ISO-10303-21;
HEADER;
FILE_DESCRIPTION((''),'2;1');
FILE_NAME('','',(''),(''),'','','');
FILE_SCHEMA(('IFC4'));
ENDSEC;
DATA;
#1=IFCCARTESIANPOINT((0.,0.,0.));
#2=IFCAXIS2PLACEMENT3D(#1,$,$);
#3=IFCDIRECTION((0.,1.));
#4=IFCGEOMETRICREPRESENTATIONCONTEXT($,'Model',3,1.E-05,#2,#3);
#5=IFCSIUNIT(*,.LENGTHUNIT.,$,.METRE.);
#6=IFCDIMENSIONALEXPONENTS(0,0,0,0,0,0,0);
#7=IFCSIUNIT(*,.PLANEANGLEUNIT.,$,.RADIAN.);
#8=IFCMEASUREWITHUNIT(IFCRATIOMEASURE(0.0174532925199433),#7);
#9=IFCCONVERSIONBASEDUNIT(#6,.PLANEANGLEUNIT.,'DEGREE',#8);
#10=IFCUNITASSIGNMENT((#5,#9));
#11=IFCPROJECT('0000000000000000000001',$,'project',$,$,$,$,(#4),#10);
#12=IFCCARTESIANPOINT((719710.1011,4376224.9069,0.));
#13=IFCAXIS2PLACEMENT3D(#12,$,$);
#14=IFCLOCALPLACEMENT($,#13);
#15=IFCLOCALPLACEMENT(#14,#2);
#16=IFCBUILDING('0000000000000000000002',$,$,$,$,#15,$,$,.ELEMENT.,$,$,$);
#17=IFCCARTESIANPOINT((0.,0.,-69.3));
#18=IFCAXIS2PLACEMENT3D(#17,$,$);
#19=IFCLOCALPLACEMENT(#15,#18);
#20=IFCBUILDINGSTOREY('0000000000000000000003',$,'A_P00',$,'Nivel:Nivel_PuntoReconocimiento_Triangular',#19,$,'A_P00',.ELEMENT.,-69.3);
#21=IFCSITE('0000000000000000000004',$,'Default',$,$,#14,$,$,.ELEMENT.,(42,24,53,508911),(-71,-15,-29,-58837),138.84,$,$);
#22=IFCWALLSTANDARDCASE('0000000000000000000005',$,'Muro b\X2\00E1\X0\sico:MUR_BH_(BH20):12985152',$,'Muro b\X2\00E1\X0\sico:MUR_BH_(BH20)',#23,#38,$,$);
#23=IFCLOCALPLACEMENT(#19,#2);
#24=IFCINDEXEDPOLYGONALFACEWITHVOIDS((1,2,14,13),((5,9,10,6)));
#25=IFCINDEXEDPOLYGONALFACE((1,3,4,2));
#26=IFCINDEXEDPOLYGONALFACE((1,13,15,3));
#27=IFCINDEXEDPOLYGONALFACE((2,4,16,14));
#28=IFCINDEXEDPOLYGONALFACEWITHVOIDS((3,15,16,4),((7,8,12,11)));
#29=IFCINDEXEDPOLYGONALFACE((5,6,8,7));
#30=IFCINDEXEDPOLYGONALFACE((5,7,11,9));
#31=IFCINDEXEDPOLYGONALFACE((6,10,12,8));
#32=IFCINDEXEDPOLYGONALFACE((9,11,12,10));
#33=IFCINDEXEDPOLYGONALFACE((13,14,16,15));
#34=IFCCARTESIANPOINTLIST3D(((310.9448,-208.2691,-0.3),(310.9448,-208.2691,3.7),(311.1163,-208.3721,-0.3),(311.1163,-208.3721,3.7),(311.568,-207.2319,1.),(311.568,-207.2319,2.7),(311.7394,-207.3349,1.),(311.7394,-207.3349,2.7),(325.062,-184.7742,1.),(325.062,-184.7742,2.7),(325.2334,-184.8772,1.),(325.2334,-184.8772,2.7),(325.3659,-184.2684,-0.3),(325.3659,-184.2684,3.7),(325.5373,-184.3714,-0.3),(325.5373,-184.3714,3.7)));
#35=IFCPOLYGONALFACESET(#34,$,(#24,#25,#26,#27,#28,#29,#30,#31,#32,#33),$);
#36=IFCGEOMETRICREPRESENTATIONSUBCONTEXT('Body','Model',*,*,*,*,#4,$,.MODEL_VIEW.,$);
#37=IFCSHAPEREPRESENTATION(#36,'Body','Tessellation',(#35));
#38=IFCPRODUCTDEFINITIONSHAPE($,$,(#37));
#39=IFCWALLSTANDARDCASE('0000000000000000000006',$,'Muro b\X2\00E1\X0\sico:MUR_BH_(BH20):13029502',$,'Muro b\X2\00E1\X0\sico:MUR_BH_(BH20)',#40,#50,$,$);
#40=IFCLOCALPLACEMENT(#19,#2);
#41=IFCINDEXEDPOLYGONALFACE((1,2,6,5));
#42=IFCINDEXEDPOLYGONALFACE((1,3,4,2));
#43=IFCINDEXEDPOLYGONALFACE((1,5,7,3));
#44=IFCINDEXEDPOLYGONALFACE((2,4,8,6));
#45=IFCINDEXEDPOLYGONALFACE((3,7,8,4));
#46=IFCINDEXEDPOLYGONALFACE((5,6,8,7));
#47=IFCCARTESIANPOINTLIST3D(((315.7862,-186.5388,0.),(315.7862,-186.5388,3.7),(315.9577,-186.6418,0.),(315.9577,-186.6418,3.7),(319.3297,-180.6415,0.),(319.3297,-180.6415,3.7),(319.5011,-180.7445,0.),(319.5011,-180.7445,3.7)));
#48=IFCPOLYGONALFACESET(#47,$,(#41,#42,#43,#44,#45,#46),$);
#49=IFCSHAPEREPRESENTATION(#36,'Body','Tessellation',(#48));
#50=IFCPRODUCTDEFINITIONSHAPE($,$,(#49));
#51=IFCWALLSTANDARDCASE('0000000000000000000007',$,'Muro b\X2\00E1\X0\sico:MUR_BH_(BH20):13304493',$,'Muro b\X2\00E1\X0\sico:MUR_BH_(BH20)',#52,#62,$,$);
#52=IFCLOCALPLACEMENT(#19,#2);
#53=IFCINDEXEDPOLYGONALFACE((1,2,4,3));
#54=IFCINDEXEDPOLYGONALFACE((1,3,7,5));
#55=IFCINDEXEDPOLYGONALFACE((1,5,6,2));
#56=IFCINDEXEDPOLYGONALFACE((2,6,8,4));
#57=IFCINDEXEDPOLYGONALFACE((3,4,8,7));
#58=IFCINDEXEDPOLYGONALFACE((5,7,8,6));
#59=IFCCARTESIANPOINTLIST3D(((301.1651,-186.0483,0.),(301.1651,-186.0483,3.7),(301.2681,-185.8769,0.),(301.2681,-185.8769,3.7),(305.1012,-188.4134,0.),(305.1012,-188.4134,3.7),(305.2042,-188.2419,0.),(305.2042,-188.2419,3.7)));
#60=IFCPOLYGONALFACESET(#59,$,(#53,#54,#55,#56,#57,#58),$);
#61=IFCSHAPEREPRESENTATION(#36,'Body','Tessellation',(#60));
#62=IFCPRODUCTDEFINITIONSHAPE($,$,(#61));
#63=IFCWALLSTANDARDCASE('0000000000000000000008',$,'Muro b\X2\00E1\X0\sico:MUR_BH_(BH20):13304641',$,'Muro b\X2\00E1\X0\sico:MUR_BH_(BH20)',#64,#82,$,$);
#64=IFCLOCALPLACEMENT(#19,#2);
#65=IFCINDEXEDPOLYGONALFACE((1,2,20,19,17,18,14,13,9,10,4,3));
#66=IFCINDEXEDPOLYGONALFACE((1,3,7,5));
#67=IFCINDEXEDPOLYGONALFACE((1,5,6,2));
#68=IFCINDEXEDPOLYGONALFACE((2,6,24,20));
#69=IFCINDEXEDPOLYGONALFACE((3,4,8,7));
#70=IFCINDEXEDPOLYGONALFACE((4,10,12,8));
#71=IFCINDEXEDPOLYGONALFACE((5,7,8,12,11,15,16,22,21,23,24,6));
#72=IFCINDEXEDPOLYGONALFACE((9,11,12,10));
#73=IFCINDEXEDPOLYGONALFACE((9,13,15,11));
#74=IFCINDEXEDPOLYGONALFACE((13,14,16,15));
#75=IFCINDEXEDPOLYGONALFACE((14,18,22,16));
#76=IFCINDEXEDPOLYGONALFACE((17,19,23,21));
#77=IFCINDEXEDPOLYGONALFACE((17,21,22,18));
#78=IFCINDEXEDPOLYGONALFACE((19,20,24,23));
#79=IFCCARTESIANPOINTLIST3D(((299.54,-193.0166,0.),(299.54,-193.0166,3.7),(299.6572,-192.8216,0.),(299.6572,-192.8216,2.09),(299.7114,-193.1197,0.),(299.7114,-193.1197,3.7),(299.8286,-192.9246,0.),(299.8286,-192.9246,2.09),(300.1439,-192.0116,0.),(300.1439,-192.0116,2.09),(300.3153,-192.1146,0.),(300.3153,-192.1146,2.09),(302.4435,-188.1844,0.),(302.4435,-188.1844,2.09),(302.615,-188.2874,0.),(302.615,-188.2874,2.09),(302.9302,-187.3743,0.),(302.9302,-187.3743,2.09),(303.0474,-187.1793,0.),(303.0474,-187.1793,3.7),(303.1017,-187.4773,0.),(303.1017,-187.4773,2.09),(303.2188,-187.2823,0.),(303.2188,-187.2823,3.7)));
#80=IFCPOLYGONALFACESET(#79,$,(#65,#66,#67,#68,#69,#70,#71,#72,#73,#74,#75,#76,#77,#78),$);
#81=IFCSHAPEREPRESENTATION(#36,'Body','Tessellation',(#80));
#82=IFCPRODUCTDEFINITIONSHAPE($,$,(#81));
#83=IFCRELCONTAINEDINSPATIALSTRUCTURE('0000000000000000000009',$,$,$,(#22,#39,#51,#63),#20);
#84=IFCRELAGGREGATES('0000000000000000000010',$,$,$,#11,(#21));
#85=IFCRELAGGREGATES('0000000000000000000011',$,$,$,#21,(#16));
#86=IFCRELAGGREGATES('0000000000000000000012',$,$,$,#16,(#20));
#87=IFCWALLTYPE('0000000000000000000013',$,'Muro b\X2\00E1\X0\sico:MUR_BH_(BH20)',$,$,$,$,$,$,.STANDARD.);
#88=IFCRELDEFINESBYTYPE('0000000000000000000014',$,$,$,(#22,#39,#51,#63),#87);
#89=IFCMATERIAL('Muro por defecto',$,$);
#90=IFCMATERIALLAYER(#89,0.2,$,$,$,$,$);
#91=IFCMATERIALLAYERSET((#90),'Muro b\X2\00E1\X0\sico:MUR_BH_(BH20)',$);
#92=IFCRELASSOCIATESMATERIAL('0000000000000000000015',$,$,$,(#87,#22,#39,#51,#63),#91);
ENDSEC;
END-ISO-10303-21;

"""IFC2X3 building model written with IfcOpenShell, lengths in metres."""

from ifc_helpers import new_model, entity, si_unit, converted_unit, direction, frame, frame_2d, origin, place, context, subcontext, project, spatial, rectangle, extrude, material, layer, layer_set, layer_usage, type_object, element, save


model = new_model("IFC2X3")

# Units and contexts
model_context = context("Model", 3, precision=1e-05, world=origin(), true_north=direction((0.0, 1.0)))
body_context = subcontext(model_context, "Body", "Model", "MODEL_VIEW")
ifc_project = project(units=[si_unit("LENGTHUNIT", "METRE"), converted_unit("PLANEANGLEUNIT", "DEGREE", entity("IfcRatioMeasure", 0.0174532925199433), si_unit("PLANEANGLEUNIT", "RADIAN"), dimensions=[0, 0, 0, 0, 0, 0, 0])], contexts=[model_context])

# Site, building, storey
site_placement = place(None, frame((719710.1011, 4376224.9069, 0.0)))
site = spatial("IfcSite", under=ifc_project, at=site_placement, Name="Default", CompositionType="ELEMENT", RefLatitude=(42, 24, 53, 508911), RefLongitude=(-71, -15, -29, -58837), RefElevation=138.84)
building_placement = place(site_placement, origin())
building = spatial("IfcBuilding", under=site, at=building_placement, CompositionType="ELEMENT")
storey_placement = place(building_placement, frame((0.0, 0.0, -69.3)))
storey = spatial("IfcBuildingStorey", under=building, at=storey_placement, Name="A_P00", ObjectType="Nivel:Nivel_PuntoReconocimiento_Triangular", LongName="A_P00", CompositionType="ELEMENT", Elevation=-69.3)

# Wall, opening
ifc_material_1 = material(Name="Muro por defecto")
ifc_layer_1 = layer(ifc_material_1, 0.2)
ifc_layer_set_1 = layer_set([ifc_layer_1], Name="Muro básico:MUR_BH_(BH20)")
ifc_layer_usage_1 = layer_usage(ifc_layer_set_1, "AXIS2", "NEGATIVE", 0.1)
wall_type = type_object("IfcWallType", Name="Muro básico:MUR_BH_(BH20)", PredefinedType="STANDARD", material=ifc_layer_set_1)
wall_1_placement = place(storey_placement, frame((325.4516, -184.3199, -0.3), z_axis=(0.0, 0.0, 1.0), x_axis=(-0.515038, -0.857167, 0.0)))
wall_1 = element("IfcWallStandardCase", 1, at=wall_1_placement, inside=storey, type_object=wall_type, material=ifc_layer_usage_1, Name="Muro básico:MUR_BH_(BH20):12985152", ObjectType="Muro básico:MUR_BH_(BH20)", context=body_context, shape_type="SweptSolid", body=[
    extrude(rectangle(XDim=28.0, YDim=0.2, at=frame_2d((14.0, 0.0), x_axis=(-1.0, 0.0))), origin(), (0.0, 0.0, 1.0), 4.0),
])
opening_1_placement = place(wall_1_placement, origin())
element("IfcOpeningElement", 2, at=opening_1_placement, cuts=wall_1, ObjectType="Opening", context=body_context, shape_type="SweptSolid", body=[
    extrude(rectangle(XDim=1.7, YDim=26.2, at=frame_2d((0.0, 0.0), x_axis=(0.0, 1.0))), frame((13.69, -0.2524, 2.15), z_axis=(0.0, 1.0, 0.0), x_axis=(-1.0, 0.0, 0.0)), (0.0, 0.0, 1.0), 0.5048),
])

# Walls
ifc_layer_usage_2 = layer_usage(ifc_layer_set_1, "AXIS2", "NEGATIVE", 0.1)
wall_2_placement = place(storey_placement, frame((315.872, -186.5903, 0.0), z_axis=(0.0, 0.0, 1.0), x_axis=(0.515038, 0.857167, 0.0)))
element("IfcWallStandardCase", 3, at=wall_2_placement, inside=storey, type_object=wall_type, material=ifc_layer_usage_2, Name="Muro básico:MUR_BH_(BH20):13029502", ObjectType="Muro básico:MUR_BH_(BH20)", context=body_context, shape_type="SweptSolid", body=[
    extrude(rectangle(XDim=6.88, YDim=0.2, at=frame_2d((3.44, 0.0), x_axis=(-1.0, 0.0))), origin(), (0.0, 0.0, 1.0), 3.7),
])
ifc_layer_usage_3 = layer_usage(ifc_layer_set_1, "AXIS2", "NEGATIVE", 0.1)
wall_3_placement = place(storey_placement, frame((305.1527, -188.3276, 0.0), z_axis=(0.0, 0.0, 1.0), x_axis=(-0.857167, 0.515038, 0.0)))
element("IfcWallStandardCase", 4, at=wall_3_placement, inside=storey, type_object=wall_type, material=ifc_layer_usage_3, Name="Muro básico:MUR_BH_(BH20):13304493", ObjectType="Muro básico:MUR_BH_(BH20)", context=body_context, shape_type="SweptSolid", body=[
    extrude(rectangle(XDim=4.592, YDim=0.2, at=frame_2d((2.296, 0.0), x_axis=(-1.0, 0.0))), origin(), (0.0, 0.0, 1.0), 3.7),
])

# Wall, openings
ifc_layer_usage_4 = layer_usage(ifc_layer_set_1, "AXIS2", "NEGATIVE", 0.1)
wall_4_placement = place(storey_placement, frame((303.1331, -187.2308, 0.0), z_axis=(0.0, 0.0, 1.0), x_axis=(-0.515038, -0.857167, 0.0)))
wall_4 = element("IfcWallStandardCase", 5, at=wall_4_placement, inside=storey, type_object=wall_type, material=ifc_layer_usage_4, Name="Muro básico:MUR_BH_(BH20):13304641", ObjectType="Muro básico:MUR_BH_(BH20)", context=body_context, shape_type="SweptSolid", body=[
    extrude(rectangle(XDim=6.81, YDim=0.2, at=frame_2d((3.405, 0.0), x_axis=(-1.0, 0.0))), origin(), (0.0, 0.0, 1.0), 3.7),
])
opening_2_placement = place(wall_4_placement, frame((-4.363, -356.2668, 0.0), z_axis=(0.0, 0.0, 1.0), x_axis=(-0.515038, 0.857167, 0.0)))
element("IfcOpeningElement", 6, at=opening_2_placement, cuts=wall_4, ObjectType="Opening", context=body_context, shape_type="SweptSolid", body=[
    extrude(rectangle(XDim=2.09, YDim=0.945, at=frame_2d((0.0, 0.0), x_axis=(1.0, 0.0))), frame((299.9005, -192.4166, 1.045), z_axis=(0.857167, -0.515038, 0.0), x_axis=(0.0, 0.0, -1.0)), (0.0, 0.0, 1.0), 0.2),
])
opening_3_placement = place(wall_4_placement, frame((-4.363, -356.2668, 0.0), z_axis=(0.0, 0.0, 1.0), x_axis=(-0.515038, 0.857167, 0.0)))
element("IfcOpeningElement", 7, at=opening_3_placement, cuts=wall_4, ObjectType="Opening", context=body_context, shape_type="SweptSolid", body=[
    extrude(rectangle(XDim=2.09, YDim=0.945, at=frame_2d((0.0, 0.0), x_axis=(0.0, 1.0))), frame((302.6869, -187.7794, 1.045), z_axis=(0.857167, -0.515038, 0.0), x_axis=(-0.515038, -0.857167, 0.0)), (0.0, 0.0, 1.0), 0.2),
])

save(model, "model.ifc")
